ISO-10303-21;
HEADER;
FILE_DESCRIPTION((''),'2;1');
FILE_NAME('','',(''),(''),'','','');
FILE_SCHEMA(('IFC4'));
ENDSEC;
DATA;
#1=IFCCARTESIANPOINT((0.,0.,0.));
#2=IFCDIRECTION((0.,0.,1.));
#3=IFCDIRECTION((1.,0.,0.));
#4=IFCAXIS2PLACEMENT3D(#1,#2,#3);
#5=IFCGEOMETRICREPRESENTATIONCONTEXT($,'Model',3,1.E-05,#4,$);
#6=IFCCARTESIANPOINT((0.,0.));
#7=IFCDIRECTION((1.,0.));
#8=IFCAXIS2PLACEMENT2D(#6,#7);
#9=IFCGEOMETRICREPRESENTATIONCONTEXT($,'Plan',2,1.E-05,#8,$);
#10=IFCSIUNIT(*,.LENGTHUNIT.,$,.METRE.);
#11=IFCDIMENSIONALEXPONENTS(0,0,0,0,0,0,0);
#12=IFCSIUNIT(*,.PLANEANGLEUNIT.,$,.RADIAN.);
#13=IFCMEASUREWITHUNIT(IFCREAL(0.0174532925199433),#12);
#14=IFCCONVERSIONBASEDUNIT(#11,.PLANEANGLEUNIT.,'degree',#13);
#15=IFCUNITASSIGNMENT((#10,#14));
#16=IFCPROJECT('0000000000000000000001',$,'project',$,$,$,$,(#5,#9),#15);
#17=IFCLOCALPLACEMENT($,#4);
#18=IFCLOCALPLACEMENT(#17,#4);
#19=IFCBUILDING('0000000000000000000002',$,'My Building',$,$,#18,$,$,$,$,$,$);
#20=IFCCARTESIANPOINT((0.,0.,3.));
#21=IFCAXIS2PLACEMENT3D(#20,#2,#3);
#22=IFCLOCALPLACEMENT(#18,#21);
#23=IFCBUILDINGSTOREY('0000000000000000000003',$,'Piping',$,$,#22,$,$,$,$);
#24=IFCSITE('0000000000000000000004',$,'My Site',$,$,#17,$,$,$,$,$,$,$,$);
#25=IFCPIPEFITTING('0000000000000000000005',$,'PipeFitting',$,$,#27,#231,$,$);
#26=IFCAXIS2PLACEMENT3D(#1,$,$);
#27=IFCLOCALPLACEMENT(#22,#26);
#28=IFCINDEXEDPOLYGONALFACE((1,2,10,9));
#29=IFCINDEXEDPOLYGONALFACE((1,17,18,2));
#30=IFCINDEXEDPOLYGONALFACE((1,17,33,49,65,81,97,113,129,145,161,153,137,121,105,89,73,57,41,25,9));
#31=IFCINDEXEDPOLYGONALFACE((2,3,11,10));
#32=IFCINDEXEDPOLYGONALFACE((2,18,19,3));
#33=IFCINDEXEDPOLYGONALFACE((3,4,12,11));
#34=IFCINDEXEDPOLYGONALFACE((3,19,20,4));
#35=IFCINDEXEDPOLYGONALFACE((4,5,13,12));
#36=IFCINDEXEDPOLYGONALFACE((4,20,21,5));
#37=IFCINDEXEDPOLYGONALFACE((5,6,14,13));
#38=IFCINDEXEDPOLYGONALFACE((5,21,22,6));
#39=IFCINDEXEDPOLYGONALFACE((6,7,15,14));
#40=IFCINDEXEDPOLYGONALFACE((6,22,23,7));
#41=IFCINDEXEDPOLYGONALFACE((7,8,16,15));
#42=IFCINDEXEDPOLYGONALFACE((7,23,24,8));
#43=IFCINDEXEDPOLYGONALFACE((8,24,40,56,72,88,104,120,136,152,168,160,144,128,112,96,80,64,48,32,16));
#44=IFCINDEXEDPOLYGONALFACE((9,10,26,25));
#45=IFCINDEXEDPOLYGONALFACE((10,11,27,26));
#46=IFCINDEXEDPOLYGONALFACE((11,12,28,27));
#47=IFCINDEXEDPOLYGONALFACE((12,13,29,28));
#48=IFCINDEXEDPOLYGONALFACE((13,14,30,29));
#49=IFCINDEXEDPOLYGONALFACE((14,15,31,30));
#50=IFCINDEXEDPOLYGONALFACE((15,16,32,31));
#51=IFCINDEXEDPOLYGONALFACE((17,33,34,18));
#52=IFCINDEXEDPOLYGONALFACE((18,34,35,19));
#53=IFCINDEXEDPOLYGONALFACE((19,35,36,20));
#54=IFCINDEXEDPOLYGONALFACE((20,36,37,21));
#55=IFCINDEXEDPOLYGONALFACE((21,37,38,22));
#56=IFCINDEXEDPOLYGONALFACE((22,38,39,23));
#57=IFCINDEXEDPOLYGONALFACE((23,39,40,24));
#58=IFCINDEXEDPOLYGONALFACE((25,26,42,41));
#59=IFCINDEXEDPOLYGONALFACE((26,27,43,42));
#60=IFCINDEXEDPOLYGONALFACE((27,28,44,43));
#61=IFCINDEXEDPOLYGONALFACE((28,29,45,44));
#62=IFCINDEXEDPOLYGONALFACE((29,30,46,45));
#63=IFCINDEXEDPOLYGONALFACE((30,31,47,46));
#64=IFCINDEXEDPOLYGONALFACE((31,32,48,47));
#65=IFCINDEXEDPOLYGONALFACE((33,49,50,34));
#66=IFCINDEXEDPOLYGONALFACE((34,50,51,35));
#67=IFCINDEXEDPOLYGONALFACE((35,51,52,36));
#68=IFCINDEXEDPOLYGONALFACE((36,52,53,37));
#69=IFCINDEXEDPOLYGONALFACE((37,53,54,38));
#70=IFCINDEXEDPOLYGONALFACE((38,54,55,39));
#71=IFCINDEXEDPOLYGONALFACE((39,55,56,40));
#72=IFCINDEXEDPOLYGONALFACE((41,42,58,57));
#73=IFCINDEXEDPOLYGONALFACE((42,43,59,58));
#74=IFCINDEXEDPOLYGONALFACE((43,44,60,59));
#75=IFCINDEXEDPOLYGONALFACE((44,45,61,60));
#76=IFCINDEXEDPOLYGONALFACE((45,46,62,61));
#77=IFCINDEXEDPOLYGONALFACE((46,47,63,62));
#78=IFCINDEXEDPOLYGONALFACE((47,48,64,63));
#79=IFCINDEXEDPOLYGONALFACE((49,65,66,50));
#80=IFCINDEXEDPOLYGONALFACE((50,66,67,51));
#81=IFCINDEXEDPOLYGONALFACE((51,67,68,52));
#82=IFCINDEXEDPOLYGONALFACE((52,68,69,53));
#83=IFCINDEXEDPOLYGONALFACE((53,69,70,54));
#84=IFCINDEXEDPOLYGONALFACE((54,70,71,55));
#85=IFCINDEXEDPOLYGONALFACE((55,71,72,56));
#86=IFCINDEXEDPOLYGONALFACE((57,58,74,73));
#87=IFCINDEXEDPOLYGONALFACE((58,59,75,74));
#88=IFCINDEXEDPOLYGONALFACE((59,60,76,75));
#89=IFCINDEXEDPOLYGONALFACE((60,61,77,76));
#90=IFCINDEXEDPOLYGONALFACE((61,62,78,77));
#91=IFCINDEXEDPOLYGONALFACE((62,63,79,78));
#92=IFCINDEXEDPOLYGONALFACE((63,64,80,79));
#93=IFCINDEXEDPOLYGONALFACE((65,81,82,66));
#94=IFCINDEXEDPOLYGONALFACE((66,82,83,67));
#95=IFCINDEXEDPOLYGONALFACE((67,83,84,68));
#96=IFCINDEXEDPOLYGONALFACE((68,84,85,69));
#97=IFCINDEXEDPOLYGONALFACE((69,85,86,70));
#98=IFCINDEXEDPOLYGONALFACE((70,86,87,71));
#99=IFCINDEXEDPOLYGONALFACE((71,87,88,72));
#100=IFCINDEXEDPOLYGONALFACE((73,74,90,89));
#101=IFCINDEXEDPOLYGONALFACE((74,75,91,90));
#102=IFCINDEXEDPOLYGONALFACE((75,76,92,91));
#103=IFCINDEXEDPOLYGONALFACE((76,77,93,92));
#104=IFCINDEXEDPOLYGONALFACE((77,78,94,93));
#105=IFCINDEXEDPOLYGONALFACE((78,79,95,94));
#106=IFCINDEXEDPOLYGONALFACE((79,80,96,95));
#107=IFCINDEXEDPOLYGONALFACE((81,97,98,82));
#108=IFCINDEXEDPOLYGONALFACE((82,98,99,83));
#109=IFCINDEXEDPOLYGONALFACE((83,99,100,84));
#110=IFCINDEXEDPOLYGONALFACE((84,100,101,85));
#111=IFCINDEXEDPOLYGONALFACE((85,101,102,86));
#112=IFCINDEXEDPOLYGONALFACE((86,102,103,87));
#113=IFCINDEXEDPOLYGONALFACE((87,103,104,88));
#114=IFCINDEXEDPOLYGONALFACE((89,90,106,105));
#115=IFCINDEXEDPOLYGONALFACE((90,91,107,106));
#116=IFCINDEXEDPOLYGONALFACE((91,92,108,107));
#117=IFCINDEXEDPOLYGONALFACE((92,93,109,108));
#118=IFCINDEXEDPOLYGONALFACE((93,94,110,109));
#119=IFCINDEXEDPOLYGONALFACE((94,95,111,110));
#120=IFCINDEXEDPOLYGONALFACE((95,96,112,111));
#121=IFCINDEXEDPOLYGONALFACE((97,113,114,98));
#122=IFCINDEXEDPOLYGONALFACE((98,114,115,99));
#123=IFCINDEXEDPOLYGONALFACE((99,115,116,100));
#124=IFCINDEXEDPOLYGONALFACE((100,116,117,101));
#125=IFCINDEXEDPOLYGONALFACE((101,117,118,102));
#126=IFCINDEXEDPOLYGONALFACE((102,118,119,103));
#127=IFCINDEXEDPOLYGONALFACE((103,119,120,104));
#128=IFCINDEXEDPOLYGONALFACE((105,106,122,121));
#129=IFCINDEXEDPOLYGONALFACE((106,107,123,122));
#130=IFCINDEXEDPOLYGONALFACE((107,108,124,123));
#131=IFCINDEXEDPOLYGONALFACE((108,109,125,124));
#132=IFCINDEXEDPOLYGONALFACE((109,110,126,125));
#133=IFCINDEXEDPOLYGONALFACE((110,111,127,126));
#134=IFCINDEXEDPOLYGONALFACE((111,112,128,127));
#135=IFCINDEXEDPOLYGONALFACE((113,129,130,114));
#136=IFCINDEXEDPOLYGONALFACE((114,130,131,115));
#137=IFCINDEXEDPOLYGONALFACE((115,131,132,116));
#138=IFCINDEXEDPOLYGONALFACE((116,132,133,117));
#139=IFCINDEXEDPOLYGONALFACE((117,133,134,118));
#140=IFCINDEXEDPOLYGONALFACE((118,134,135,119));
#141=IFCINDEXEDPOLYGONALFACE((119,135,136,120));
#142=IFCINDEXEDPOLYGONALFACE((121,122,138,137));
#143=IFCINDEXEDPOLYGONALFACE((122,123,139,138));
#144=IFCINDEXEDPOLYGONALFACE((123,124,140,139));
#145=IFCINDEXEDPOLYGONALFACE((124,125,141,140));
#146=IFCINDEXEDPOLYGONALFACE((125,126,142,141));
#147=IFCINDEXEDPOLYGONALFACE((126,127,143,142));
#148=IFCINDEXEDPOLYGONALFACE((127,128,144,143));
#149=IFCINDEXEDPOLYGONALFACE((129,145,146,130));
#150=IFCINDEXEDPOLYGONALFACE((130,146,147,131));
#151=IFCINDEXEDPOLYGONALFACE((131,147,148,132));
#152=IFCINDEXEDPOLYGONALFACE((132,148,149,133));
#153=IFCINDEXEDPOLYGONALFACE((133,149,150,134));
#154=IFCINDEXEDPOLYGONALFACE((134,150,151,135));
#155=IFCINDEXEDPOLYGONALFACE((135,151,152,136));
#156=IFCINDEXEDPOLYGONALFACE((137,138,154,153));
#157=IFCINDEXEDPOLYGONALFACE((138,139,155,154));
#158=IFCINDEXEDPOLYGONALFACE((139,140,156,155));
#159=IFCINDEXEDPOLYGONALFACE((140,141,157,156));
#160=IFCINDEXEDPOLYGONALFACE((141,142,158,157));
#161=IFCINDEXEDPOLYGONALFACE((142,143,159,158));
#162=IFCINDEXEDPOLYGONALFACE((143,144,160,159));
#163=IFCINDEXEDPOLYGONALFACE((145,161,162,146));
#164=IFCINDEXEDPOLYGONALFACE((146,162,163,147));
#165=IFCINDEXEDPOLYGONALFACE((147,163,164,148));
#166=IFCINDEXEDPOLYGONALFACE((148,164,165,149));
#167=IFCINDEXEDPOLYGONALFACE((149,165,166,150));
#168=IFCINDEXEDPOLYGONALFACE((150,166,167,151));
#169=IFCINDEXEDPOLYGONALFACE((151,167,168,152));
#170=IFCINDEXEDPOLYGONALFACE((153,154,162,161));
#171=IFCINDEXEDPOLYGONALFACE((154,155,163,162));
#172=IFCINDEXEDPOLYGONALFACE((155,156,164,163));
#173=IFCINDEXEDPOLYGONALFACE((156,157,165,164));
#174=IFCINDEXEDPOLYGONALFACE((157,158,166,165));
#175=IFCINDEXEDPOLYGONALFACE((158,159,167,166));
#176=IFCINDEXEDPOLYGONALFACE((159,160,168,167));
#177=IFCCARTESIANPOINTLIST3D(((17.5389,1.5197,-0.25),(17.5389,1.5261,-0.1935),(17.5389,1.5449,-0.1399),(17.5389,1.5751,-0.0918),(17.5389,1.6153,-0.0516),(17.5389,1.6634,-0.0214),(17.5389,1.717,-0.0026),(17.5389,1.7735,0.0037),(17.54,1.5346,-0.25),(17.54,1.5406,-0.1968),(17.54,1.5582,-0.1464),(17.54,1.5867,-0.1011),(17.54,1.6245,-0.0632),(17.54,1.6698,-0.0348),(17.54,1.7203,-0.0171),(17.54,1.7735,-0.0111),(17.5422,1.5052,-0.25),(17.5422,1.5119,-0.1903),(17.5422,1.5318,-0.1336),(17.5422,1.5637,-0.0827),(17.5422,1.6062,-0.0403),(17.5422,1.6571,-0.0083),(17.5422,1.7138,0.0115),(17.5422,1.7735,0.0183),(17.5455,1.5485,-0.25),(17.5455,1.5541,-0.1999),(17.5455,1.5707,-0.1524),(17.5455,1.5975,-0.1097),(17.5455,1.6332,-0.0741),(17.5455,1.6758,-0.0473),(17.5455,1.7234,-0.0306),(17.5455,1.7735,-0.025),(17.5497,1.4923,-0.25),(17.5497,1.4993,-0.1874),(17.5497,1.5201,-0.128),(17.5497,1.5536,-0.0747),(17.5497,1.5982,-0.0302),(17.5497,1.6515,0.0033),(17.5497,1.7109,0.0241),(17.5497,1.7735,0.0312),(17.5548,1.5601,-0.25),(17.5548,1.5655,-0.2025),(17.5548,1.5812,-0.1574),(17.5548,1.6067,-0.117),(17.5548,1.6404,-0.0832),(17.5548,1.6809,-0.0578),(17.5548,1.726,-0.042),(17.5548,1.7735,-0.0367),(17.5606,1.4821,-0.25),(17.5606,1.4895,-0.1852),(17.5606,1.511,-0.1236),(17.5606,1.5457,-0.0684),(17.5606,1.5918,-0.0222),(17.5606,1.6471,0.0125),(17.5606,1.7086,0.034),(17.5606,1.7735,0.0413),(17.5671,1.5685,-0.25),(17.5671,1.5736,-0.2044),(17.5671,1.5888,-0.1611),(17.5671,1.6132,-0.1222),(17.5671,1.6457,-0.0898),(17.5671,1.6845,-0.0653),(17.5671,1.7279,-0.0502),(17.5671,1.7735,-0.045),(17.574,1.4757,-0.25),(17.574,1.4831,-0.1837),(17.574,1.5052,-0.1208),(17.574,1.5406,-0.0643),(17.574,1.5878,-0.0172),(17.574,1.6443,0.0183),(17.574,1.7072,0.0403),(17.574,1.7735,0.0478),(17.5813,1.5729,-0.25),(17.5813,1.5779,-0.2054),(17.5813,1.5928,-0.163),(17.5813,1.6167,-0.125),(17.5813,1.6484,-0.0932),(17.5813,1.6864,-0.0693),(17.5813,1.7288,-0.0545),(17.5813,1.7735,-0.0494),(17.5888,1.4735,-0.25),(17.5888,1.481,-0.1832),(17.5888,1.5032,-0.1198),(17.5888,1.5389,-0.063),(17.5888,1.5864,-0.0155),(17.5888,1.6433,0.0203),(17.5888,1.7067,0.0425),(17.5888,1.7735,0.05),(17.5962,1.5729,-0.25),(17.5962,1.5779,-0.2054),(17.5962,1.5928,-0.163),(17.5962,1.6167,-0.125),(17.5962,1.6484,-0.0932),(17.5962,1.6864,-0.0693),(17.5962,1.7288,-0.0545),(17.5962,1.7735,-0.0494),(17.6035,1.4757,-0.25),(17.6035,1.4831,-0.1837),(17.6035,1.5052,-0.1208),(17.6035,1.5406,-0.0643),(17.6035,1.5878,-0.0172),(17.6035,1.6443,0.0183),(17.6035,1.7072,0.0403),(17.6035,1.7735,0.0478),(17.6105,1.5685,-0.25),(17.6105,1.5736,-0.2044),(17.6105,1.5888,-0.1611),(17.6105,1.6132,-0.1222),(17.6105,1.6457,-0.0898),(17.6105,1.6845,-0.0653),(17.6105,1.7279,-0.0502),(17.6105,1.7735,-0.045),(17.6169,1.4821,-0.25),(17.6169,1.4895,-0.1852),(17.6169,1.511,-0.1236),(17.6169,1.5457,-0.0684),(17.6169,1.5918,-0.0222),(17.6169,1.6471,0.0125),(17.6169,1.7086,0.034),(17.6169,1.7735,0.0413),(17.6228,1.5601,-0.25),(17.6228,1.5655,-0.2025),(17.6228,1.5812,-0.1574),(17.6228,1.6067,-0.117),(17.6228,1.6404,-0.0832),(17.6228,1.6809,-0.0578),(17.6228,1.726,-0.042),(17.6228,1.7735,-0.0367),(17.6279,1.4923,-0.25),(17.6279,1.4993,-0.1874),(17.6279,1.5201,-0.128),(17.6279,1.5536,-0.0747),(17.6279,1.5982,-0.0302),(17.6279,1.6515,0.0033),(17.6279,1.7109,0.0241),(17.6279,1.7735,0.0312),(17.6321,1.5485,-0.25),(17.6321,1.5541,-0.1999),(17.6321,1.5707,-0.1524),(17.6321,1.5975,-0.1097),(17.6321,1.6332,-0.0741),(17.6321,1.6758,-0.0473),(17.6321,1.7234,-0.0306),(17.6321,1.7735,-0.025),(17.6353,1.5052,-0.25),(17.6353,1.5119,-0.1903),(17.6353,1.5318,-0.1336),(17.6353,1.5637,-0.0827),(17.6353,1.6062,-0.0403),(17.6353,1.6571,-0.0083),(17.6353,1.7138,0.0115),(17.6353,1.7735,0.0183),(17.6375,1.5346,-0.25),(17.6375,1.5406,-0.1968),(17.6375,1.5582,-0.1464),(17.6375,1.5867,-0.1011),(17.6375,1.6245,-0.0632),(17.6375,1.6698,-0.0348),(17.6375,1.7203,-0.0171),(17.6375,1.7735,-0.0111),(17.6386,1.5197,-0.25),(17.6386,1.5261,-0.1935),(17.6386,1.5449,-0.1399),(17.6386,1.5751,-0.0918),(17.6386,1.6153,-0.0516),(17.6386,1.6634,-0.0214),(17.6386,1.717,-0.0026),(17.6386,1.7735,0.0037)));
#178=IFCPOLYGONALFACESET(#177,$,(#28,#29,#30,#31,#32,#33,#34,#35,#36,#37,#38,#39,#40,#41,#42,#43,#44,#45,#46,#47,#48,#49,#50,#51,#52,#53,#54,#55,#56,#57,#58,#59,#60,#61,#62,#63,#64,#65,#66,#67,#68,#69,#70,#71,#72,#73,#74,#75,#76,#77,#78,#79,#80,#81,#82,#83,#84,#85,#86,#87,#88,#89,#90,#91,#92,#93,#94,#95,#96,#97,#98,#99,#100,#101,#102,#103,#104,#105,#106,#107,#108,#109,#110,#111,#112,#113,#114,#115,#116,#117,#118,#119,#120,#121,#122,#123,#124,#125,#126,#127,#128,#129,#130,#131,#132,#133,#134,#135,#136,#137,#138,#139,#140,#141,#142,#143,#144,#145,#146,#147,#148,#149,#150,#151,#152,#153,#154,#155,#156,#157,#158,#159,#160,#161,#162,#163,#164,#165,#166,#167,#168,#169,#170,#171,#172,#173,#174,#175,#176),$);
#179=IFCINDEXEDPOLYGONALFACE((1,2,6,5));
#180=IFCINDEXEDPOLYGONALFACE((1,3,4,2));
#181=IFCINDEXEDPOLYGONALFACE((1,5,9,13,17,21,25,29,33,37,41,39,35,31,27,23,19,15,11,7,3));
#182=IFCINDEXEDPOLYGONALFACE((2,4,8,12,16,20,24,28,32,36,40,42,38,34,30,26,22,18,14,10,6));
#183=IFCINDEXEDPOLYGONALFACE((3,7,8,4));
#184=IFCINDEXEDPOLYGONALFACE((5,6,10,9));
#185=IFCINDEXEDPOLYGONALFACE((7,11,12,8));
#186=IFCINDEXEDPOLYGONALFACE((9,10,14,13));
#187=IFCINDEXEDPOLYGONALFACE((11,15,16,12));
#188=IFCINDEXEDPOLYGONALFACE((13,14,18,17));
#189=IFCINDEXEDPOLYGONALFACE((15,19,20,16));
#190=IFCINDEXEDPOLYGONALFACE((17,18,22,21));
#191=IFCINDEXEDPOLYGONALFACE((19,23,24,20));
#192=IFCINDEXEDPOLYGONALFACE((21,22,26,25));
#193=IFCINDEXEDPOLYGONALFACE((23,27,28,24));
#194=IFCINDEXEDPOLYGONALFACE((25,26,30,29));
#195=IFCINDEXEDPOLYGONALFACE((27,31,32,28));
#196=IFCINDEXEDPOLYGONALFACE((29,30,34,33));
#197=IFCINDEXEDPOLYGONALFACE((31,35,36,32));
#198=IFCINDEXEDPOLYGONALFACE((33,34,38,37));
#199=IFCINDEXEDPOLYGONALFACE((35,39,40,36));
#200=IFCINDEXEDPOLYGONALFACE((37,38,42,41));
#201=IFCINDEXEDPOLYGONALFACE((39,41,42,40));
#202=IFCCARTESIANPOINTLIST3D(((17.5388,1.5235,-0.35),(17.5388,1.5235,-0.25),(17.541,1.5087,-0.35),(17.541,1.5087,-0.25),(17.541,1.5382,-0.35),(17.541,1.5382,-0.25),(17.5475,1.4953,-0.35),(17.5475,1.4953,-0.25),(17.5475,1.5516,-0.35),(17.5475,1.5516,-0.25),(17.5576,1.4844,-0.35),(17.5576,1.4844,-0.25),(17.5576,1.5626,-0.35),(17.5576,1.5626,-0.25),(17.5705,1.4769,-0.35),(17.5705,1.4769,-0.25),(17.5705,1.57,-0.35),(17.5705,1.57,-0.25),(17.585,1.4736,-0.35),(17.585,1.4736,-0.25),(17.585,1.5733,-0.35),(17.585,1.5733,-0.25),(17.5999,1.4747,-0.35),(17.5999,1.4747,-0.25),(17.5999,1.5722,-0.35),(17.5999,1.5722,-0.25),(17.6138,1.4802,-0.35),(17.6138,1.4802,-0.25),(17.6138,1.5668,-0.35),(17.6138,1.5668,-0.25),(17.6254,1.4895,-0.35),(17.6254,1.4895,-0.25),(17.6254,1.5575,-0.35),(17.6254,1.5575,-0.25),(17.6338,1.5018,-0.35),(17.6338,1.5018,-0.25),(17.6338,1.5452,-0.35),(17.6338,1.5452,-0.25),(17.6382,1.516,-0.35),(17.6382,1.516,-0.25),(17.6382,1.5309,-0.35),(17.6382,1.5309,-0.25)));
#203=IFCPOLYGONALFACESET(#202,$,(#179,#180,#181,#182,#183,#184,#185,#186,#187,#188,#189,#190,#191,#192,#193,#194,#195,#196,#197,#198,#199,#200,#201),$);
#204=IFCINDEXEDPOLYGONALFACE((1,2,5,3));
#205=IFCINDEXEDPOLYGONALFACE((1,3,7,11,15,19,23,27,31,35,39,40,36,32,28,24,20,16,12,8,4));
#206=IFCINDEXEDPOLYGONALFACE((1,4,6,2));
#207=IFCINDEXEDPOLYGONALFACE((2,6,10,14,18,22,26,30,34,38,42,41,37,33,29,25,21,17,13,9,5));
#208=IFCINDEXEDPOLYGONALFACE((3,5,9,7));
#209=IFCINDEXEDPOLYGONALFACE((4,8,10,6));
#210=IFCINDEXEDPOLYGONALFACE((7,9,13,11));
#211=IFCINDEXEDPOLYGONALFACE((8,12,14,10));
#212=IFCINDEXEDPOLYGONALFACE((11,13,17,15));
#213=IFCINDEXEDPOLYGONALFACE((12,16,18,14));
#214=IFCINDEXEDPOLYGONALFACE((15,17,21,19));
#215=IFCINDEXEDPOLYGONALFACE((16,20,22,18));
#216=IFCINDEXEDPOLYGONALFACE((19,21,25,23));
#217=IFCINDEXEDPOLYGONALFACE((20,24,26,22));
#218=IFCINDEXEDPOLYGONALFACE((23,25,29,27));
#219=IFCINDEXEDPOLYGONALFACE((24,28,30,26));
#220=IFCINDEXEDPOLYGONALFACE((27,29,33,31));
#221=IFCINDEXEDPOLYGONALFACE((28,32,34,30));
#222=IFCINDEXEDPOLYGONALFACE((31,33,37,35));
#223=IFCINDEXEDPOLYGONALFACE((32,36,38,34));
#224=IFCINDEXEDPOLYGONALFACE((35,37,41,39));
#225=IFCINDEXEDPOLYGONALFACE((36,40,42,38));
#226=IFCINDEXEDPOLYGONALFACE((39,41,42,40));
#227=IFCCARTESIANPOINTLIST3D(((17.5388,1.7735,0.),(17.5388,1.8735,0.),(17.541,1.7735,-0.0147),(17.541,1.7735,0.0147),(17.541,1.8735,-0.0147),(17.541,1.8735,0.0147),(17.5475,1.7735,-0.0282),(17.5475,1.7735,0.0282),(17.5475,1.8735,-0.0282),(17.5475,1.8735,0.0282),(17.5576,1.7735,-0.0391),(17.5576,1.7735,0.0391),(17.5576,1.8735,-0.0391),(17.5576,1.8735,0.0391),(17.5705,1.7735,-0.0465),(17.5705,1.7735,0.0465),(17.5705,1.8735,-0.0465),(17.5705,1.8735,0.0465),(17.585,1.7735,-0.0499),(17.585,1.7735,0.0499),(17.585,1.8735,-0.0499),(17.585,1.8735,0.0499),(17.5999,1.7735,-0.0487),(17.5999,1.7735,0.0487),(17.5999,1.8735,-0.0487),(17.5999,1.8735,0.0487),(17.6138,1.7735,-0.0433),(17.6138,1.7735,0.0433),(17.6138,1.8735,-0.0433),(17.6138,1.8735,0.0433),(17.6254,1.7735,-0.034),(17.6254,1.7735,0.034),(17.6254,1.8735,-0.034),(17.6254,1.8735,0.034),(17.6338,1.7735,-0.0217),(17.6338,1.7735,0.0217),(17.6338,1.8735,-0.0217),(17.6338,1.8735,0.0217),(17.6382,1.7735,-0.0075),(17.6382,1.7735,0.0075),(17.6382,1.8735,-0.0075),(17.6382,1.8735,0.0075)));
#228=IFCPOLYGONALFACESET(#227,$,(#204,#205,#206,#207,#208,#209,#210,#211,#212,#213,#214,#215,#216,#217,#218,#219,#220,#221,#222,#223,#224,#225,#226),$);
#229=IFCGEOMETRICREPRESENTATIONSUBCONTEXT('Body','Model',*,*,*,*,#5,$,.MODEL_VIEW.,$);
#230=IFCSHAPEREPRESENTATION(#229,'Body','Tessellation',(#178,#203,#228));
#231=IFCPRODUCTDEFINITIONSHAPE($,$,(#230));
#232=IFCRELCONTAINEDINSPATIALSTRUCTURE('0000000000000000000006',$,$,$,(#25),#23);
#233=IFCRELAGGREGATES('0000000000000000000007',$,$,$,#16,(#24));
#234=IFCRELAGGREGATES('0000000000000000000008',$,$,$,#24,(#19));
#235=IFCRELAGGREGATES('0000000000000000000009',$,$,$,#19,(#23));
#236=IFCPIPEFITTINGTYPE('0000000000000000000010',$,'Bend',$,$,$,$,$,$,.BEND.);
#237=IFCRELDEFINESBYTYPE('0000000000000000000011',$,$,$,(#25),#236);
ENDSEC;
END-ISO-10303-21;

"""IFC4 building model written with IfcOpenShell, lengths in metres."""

from ifc_helpers import new_model, entity, si_unit, converted_unit, frame, origin_with_axes, origin_2d_with_axis, place, context, subcontext, project, spatial, line, indexed_curve, circle, outline, extrude, source, transform, mapped, type_object, type_shapes, element, save


model = new_model("IFC4")

# Units and contexts
model_context = context("Model", 3, precision=1e-05, world=origin_with_axes())
plan_context = context("Plan", 2, precision=1e-05, world=origin_2d_with_axis())
body_context = subcontext(model_context, "Body", "Model", "MODEL_VIEW")
ifc_project = project(units=[si_unit("LENGTHUNIT", "METRE"), converted_unit("PLANEANGLEUNIT", "degree", entity("IfcReal", 0.0174532925199433), si_unit("PLANEANGLEUNIT", "RADIAN"), dimensions=[0, 0, 0, 0, 0, 0, 0])], contexts=[model_context, plan_context])

# Site, building, storey
site_placement = place(None, origin_with_axes())
site = spatial("IfcSite", under=ifc_project, at=site_placement, Name="My Site")
building_placement = place(site_placement, origin_with_axes())
building = spatial("IfcBuilding", under=site, at=building_placement, Name="My Building")
storey_placement = place(building_placement, frame((0.0, 0.0, 3.0), z_axis=(0.0, 0.0, 1.0), x_axis=(1.0, 0.0, 0.0)))
storey = spatial("IfcBuildingStorey", under=building, at=storey_placement, Name="Piping")

# Pipe fitting, opening
pipe_fitting_type = type_object("IfcPipeFittingType", Name="Bend", PredefinedType="BEND")
shared_shape = source(origin_with_axes(), body_context, "Body", "SolidModel", [
    entity("IfcSweptDiskSolid", entity("IfcIndexedPolyCurve", entity("IfcCartesianPointList3D", [[0.0, 0.0, -0.1], [0.0, 0.0732, -0.2768], [0.0, 0.25, -0.35]]), [entity("IfcArcIndex", [1, 2, 3])]), 0.05),
    extrude(circle(Radius=0.05), origin_with_axes(), (0.0, 0.0, -1.0), 0.1),
    extrude(circle(Radius=0.05), frame((0.0, 0.25, -0.35), z_axis=(0.0, 1.0, 0.0), x_axis=(1.0, 0.0, 0.0)), (0.0, 0.0, 1.0), 0.1),
])
type_shapes(pipe_fitting_type, [shared_shape])
pipe_fitting_1_placement = place(storey_placement, frame((17.5888, 1.5235, -0.35), z_axis=(0.0, 0.0, -1.0), x_axis=(-1.0, 0.0, 0.0)))
pipe_fitting_1 = element("IfcPipeFitting", 1, at=pipe_fitting_1_placement, inside=storey, type_object=pipe_fitting_type, Name="PipeFitting", context=body_context, shape_type="MappedRepresentation", body=[
    mapped(shared_shape, transform((0.0, 0.0, 0.0), x_axis=(1.0, 0.0, 0.0), y_axis=(0.0, 1.0, 0.0), z_axis=(0.0, 0.0, 1.0), scale=1.0)),
])
opening_1_placement = place(pipe_fitting_1_placement, frame((1.9673, -1.5235, 2.65), z_axis=(0.0, 0.0, -1.0), x_axis=(-1.0, 0.0, 0.0)))
element("IfcOpeningElement", 2, at=opening_1_placement, cuts=pipe_fitting_1, PredefinedType="OPENING", context=body_context, shape_type="SweptSolid", body=[
    extrude(outline(indexed_curve([(0.0, 0.0), (0.5, 0.0), (0.5, 0.5), (0.0, 0.5)], segments=[line(1, 2, 3, 4, 1)])), origin_with_axes(), (0.0, 0.0, 1.0), 0.5),
])

save(model, "model.ifc")
